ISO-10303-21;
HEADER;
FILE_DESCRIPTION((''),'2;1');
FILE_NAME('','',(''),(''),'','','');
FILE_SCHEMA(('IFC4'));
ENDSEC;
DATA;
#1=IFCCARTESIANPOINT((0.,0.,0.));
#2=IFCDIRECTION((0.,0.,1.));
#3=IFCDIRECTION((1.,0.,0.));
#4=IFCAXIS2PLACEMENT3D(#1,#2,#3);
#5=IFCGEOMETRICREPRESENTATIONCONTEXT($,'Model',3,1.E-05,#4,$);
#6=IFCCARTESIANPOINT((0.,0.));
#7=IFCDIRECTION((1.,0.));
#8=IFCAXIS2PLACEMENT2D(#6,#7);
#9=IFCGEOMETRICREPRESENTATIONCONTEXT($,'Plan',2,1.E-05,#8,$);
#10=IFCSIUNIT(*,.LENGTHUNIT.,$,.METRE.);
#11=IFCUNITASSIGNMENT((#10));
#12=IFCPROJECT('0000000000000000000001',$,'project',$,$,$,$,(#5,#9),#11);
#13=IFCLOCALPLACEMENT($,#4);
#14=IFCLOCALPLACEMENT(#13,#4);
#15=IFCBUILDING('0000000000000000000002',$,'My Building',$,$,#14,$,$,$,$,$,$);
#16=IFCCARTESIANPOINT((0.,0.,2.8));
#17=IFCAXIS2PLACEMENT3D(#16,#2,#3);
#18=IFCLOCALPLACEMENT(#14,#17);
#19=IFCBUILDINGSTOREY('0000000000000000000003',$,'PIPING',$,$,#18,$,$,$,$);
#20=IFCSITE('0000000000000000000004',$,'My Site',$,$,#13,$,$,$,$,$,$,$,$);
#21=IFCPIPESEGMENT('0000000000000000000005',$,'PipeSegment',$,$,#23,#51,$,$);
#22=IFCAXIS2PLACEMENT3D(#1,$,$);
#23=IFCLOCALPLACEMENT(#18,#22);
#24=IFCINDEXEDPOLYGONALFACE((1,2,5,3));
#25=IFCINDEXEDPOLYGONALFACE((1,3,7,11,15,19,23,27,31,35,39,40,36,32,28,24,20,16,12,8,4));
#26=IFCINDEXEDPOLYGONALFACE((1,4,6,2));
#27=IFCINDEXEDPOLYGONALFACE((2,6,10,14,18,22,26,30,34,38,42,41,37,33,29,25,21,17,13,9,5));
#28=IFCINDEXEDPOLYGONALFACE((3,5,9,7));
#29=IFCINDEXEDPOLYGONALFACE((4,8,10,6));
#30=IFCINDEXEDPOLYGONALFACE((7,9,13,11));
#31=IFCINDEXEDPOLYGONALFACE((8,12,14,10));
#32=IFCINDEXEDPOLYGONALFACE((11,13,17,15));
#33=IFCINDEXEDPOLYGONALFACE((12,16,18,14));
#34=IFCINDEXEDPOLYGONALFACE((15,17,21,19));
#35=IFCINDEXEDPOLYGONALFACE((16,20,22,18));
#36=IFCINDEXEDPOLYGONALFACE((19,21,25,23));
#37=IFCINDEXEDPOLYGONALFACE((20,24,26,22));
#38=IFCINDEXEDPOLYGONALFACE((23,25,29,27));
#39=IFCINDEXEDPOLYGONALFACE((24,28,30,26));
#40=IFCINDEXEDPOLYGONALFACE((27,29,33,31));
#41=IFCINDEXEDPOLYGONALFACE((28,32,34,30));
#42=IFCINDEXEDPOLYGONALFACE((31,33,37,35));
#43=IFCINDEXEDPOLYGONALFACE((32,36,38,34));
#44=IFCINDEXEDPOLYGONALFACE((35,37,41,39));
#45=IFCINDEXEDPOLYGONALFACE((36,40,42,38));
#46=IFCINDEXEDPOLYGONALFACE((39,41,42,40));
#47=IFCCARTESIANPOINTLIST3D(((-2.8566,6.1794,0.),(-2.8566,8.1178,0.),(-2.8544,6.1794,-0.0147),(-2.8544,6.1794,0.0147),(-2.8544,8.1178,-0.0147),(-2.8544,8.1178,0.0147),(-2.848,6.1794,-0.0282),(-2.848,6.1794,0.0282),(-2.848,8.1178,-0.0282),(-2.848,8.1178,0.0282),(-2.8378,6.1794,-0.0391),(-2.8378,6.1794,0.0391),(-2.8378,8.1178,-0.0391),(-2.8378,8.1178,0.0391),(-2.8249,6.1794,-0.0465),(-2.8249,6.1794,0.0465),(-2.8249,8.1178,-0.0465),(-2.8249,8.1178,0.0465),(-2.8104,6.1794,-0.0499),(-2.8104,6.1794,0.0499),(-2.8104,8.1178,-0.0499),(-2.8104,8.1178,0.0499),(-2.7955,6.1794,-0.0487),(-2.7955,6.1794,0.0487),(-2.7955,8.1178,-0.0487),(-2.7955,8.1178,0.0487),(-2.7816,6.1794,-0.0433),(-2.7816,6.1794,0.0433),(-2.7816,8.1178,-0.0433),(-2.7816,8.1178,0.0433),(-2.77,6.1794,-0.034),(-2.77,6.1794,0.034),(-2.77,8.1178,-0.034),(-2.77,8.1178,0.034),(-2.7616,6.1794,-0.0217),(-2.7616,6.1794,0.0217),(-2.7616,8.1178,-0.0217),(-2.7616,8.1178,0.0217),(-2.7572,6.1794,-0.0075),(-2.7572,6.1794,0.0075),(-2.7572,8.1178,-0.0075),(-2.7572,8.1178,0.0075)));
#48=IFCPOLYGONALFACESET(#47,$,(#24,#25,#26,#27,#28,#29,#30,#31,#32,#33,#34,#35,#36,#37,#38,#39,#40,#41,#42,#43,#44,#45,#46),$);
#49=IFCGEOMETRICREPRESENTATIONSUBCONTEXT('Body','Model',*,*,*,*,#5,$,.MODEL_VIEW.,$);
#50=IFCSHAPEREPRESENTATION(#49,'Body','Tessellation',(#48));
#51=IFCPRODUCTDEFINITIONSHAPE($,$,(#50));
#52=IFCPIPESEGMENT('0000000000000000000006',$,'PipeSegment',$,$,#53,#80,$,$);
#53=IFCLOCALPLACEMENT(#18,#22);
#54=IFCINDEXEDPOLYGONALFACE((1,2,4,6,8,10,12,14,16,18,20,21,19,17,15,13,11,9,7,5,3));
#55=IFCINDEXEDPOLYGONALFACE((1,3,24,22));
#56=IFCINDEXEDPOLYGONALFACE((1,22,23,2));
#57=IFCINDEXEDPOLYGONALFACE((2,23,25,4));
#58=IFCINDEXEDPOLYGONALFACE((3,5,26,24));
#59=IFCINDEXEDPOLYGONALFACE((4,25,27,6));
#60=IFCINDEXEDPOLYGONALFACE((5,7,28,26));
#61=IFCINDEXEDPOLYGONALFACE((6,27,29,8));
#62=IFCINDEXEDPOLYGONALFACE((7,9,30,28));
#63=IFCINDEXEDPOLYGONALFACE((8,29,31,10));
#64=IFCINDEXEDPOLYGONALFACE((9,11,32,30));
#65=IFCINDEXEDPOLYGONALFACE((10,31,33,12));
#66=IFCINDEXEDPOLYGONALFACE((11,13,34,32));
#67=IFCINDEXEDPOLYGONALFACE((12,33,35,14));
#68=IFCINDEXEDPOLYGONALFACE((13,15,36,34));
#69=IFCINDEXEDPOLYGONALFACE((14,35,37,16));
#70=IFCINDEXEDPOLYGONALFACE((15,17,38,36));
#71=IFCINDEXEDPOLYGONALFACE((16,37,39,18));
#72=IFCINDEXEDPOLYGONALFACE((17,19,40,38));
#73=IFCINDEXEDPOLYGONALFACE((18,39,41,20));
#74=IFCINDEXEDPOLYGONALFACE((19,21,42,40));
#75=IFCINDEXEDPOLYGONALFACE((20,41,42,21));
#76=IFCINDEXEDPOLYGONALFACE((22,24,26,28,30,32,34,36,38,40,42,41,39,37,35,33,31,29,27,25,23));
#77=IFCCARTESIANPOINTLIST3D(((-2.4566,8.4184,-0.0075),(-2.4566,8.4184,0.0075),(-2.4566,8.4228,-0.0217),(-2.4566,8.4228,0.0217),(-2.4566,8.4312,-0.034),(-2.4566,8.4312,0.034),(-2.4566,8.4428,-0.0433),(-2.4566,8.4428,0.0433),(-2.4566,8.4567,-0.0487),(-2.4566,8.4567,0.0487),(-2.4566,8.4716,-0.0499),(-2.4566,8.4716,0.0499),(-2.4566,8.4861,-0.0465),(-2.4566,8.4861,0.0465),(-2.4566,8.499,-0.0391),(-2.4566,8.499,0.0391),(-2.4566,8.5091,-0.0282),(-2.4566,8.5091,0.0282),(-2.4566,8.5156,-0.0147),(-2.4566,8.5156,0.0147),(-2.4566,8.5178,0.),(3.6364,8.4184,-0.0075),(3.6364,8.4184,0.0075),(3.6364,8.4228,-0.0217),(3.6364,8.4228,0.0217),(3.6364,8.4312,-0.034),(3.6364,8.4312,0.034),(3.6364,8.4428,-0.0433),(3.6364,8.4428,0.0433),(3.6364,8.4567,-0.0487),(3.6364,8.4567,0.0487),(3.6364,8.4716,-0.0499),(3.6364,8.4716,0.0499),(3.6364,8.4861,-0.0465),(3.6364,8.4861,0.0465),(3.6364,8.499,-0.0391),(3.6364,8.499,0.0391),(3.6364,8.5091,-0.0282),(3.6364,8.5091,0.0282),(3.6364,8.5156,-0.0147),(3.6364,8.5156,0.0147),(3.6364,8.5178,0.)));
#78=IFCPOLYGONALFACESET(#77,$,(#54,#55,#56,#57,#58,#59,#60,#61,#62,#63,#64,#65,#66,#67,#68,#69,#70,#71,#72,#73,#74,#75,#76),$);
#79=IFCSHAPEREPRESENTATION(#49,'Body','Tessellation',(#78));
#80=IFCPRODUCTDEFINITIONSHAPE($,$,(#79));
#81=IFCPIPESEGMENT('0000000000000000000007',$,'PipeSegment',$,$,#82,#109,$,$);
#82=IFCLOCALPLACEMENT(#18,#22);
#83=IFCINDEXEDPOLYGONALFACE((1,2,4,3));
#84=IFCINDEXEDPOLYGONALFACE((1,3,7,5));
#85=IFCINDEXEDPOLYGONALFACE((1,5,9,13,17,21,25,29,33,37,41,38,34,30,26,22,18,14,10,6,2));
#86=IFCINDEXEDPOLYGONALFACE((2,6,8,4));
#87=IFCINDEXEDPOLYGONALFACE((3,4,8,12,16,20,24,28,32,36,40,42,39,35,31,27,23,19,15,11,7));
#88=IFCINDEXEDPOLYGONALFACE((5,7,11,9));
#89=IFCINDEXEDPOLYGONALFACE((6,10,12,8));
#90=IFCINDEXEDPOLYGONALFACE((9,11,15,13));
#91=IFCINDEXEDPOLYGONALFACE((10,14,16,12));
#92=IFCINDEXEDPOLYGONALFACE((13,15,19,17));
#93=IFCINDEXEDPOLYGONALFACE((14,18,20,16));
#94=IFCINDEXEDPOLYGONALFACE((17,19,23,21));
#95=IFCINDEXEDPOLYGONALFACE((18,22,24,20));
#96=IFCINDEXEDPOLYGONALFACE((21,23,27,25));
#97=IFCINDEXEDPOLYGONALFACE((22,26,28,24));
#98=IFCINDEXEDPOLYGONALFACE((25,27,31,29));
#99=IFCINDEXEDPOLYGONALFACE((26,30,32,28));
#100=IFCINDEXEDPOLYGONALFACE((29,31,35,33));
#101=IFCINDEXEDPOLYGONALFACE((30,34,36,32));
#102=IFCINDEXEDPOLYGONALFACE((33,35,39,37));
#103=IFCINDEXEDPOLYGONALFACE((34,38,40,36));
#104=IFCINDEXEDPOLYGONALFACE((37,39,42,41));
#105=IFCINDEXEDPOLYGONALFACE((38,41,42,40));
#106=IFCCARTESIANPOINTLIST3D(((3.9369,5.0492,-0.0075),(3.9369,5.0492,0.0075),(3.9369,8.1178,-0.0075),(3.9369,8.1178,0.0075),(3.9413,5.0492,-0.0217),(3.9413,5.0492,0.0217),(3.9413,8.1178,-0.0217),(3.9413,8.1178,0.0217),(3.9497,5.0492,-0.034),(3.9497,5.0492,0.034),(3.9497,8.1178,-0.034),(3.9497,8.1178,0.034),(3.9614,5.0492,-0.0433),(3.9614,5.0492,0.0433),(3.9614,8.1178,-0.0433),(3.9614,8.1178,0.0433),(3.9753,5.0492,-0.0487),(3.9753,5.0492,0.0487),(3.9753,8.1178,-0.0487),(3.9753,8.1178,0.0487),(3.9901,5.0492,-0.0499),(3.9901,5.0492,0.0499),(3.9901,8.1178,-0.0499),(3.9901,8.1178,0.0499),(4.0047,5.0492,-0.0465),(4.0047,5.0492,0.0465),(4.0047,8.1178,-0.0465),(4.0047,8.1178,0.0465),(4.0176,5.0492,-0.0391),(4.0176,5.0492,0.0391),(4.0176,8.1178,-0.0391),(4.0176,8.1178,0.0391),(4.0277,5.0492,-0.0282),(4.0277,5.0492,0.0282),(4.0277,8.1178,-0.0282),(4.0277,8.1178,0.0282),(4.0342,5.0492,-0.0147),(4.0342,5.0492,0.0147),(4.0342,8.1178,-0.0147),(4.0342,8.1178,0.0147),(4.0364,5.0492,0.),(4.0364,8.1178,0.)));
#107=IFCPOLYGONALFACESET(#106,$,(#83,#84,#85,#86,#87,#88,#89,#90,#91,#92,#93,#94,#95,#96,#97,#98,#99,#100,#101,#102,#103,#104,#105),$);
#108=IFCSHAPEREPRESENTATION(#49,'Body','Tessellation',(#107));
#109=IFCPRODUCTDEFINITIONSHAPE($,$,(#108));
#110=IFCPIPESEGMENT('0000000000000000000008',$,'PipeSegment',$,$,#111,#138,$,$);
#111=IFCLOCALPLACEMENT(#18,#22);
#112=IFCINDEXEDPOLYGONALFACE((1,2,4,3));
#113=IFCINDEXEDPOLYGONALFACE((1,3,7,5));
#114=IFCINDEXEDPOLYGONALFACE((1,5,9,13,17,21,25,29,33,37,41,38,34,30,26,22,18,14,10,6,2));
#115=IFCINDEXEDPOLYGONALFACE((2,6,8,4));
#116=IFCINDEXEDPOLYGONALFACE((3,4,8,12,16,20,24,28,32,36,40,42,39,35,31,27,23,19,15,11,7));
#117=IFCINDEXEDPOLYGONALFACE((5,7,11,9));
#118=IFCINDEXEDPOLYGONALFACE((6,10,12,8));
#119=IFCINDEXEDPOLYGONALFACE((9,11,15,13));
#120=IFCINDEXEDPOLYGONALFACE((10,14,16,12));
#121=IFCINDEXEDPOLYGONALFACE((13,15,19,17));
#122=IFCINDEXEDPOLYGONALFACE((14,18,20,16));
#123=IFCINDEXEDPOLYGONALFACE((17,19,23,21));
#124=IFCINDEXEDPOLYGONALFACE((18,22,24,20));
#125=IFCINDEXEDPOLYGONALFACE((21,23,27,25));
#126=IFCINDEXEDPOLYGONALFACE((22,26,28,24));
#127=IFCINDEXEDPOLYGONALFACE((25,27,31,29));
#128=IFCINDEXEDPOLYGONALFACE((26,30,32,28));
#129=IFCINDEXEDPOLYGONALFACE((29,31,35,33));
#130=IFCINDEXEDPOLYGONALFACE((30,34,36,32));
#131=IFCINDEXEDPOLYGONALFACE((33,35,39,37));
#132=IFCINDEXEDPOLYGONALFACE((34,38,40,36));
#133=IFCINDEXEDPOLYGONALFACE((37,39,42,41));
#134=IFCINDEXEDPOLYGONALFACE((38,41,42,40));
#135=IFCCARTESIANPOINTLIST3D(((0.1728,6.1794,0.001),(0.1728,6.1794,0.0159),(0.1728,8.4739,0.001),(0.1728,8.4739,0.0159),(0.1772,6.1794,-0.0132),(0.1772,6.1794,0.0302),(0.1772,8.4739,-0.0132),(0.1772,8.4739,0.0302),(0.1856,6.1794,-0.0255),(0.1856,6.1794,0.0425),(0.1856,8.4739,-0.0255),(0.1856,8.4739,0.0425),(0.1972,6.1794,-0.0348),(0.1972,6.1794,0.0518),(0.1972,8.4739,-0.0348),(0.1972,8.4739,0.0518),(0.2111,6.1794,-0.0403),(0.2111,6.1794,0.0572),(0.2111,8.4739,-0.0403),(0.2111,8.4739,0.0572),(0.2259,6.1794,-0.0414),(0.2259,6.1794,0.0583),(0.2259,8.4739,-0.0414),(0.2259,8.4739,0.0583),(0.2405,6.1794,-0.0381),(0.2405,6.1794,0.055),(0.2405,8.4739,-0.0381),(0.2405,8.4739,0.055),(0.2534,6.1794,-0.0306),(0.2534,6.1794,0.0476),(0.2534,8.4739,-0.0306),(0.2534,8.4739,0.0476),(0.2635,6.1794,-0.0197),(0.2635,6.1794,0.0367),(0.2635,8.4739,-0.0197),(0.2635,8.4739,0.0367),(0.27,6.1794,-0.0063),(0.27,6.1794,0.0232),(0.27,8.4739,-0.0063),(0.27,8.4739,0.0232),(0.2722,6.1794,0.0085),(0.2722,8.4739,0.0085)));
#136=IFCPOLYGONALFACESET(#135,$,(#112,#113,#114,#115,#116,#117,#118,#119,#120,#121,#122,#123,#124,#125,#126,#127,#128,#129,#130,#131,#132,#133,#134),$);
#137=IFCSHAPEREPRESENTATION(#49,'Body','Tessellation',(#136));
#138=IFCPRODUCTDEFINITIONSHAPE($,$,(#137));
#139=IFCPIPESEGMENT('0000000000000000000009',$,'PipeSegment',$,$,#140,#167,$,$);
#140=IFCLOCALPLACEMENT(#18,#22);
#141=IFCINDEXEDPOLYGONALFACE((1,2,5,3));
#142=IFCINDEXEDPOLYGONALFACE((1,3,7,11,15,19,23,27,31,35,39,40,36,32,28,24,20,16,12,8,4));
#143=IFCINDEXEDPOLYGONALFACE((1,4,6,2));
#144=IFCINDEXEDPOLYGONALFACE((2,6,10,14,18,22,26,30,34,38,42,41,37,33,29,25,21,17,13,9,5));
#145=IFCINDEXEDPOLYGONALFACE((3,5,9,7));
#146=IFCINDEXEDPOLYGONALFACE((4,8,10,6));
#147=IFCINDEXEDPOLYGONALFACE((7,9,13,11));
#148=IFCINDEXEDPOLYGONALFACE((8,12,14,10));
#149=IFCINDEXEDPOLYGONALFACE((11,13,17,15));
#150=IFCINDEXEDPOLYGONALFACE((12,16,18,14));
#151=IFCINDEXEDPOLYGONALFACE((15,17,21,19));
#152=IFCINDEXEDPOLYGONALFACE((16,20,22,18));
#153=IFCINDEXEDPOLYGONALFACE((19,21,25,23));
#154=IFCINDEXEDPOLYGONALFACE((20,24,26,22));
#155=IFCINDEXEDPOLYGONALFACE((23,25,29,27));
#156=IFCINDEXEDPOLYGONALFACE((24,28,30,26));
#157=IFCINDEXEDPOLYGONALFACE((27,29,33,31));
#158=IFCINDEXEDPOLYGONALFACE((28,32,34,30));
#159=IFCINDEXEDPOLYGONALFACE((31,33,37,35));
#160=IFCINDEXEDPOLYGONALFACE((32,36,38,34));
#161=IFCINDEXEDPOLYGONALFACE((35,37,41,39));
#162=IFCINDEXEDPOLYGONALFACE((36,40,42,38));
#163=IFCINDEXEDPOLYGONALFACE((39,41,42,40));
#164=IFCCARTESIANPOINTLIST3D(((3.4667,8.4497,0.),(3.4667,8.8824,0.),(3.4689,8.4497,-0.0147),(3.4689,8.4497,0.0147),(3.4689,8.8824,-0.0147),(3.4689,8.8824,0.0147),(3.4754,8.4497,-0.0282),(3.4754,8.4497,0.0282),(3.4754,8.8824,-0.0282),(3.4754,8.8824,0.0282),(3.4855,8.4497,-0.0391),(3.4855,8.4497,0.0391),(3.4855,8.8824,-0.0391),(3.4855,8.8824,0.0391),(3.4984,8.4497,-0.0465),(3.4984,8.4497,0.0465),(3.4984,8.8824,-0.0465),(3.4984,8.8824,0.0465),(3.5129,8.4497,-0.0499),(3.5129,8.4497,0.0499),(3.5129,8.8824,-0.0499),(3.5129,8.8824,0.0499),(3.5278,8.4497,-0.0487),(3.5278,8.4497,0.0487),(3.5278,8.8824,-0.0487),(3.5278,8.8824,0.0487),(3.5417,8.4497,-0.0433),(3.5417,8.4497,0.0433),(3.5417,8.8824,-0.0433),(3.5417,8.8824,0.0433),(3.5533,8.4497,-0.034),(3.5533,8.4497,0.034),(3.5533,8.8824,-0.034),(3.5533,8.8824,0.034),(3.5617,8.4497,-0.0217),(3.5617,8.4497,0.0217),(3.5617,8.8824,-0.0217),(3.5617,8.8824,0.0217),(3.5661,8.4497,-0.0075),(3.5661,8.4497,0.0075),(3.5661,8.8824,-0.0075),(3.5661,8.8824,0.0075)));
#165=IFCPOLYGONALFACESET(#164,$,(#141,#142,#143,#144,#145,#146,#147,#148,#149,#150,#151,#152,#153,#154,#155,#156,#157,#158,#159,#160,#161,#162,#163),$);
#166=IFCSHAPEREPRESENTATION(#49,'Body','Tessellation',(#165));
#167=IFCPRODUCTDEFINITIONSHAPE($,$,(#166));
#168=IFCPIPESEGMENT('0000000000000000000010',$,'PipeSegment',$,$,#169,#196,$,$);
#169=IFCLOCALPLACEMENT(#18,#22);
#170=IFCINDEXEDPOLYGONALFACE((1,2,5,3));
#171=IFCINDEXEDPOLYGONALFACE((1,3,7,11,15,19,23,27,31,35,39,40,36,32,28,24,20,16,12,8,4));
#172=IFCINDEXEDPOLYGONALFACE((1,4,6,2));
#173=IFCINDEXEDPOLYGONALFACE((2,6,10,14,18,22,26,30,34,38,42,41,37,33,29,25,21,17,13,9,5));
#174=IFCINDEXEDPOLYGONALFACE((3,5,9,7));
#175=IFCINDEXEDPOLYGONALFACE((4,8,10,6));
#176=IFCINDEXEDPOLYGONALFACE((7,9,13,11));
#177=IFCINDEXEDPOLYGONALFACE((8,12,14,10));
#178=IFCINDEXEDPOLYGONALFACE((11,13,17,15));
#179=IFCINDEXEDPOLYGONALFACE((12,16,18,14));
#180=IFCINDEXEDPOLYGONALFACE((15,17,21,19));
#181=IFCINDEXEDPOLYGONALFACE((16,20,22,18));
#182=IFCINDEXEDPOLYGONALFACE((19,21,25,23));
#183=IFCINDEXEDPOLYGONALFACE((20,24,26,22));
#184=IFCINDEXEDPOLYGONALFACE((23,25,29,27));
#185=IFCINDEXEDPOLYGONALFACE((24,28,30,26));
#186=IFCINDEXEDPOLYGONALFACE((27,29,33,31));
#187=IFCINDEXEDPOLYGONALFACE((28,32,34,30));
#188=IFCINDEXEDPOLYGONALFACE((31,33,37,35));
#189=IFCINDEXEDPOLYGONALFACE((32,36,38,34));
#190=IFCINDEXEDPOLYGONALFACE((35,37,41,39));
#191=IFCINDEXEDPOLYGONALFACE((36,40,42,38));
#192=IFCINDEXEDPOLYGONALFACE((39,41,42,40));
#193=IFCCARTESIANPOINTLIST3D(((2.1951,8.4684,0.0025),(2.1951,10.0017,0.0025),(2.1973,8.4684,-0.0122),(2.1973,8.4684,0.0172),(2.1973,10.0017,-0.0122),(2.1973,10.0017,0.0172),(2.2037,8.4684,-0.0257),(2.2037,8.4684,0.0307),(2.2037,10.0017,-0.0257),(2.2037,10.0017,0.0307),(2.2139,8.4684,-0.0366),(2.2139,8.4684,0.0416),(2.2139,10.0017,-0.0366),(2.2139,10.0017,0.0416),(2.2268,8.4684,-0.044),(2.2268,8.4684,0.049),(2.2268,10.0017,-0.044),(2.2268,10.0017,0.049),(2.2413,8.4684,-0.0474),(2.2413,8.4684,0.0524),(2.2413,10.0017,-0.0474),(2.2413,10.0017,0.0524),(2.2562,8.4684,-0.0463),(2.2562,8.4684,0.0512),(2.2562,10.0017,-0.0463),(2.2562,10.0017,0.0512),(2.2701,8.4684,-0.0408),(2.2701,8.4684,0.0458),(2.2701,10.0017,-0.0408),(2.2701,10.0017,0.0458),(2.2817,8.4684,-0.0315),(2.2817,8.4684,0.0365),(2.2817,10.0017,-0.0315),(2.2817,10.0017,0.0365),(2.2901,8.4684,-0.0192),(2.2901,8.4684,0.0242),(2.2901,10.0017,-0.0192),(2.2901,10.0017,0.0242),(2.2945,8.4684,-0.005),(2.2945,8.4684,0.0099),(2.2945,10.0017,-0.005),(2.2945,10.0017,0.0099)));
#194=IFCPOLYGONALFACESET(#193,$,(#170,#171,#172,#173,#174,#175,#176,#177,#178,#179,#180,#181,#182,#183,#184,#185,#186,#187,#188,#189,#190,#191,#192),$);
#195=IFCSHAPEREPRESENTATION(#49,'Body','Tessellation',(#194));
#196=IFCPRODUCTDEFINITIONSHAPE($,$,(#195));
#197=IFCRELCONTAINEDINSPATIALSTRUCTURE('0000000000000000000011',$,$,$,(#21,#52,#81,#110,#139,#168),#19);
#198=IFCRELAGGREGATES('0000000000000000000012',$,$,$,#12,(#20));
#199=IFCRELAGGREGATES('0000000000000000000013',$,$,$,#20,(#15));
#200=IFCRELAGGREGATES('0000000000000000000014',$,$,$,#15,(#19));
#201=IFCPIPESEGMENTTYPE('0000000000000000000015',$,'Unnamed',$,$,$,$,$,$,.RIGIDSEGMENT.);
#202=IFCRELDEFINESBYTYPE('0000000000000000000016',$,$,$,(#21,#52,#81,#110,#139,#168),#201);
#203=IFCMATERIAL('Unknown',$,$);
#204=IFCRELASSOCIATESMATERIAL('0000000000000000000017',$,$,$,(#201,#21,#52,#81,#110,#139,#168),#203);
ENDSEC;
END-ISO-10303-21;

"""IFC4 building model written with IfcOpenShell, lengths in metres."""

from ifc_helpers import new_model, si_unit, frame, origin_with_axes, origin_2d_with_axis, place, context, subcontext, project, spatial, circle, extrude, material, material_profile, profile_set, profile_usage, type_object, element, save


model = new_model("IFC4")

# Units and contexts
model_context = context("Model", 3, precision=1e-05, world=origin_with_axes())
plan_context = context("Plan", 2, precision=1e-05, world=origin_2d_with_axis())
body_context = subcontext(model_context, "Body", "Model", "MODEL_VIEW")
ifc_project = project(units=[si_unit("LENGTHUNIT", "METRE")], contexts=[model_context, plan_context])

# Site, building, storey
site_placement = place(None, origin_with_axes())
site = spatial("IfcSite", under=ifc_project, at=site_placement, Name="My Site")
building_placement = place(site_placement, origin_with_axes())
building = spatial("IfcBuilding", under=site, at=building_placement, Name="My Building")
storey_placement = place(building_placement, frame((0.0, 0.0, 2.8), z_axis=(0.0, 0.0, 1.0), x_axis=(1.0, 0.0, 0.0)))
storey = spatial("IfcBuildingStorey", under=building, at=storey_placement, Name="PIPING")

# Pipe segments
ifc_material = material(Name="Unknown")
ifc_material_profile = material_profile(ifc_material, circle(Radius=0.05))
ifc_profile_set = profile_set([ifc_material_profile])
ifc_profile_usage_1 = profile_usage(ifc_profile_set, cardinal=5)
pipe_segment_type = type_object("IfcPipeSegmentType", Name="Unnamed", PredefinedType="RIGIDSEGMENT", material=ifc_profile_set)
pipe_segment_1_placement = place(storey_placement, frame((-2.8066, 6.1794, 0.0), z_axis=(0.0, 1.0, 0.0), x_axis=(-1.0, 0.0, 0.0)))
element("IfcPipeSegment", 1, at=pipe_segment_1_placement, inside=storey, type_object=pipe_segment_type, material=ifc_profile_usage_1, Name="PipeSegment", context=body_context, shape_type="SweptSolid", body=[
    extrude(circle(Radius=0.05), origin_with_axes(), (0.0, 0.0, 1.0), 1.9384),
])
ifc_profile_usage_2 = profile_usage(ifc_profile_set, cardinal=5)
pipe_segment_2_placement = place(storey_placement, frame((-2.4566, 8.4678, 0.0), z_axis=(1.0, 0.0, 0.0), x_axis=(0.0, 1.0, 0.0)))
element("IfcPipeSegment", 2, at=pipe_segment_2_placement, inside=storey, type_object=pipe_segment_type, material=ifc_profile_usage_2, Name="PipeSegment", context=body_context, shape_type="SweptSolid", body=[
    extrude(circle(Radius=0.05), origin_with_axes(), (0.0, 0.0, 1.0), 6.093),
])
ifc_profile_usage_3 = profile_usage(ifc_profile_set, cardinal=5)
pipe_segment_3_placement = place(storey_placement, frame((3.9864, 8.1178, 0.0), z_axis=(0.0, -1.0, 0.0), x_axis=(1.0, 0.0, 0.0)))
element("IfcPipeSegment", 3, at=pipe_segment_3_placement, inside=storey, type_object=pipe_segment_type, material=ifc_profile_usage_3, Name="PipeSegment", context=body_context, shape_type="SweptSolid", body=[
    extrude(circle(Radius=0.05), origin_with_axes(), (0.0, 0.0, 1.0), 3.0686),
])
ifc_profile_usage_4 = profile_usage(ifc_profile_set, cardinal=5)
pipe_segment_4_placement = place(storey_placement, frame((0.2222, 8.4739, 0.0085), z_axis=(0.0, -1.0, 0.0), x_axis=(1.0, 0.0, 0.0)))
element("IfcPipeSegment", 4, at=pipe_segment_4_placement, inside=storey, type_object=pipe_segment_type, material=ifc_profile_usage_4, Name="PipeSegment", context=body_context, shape_type="SweptSolid", body=[
    extrude(circle(Radius=0.05), origin_with_axes(), (0.0, 0.0, 1.0), 2.2944),
])
ifc_profile_usage_5 = profile_usage(ifc_profile_set, cardinal=5)
pipe_segment_5_placement = place(storey_placement, frame((3.5167, 8.4497, 0.0), z_axis=(0.0, 1.0, 0.0), x_axis=(-1.0, 0.0, 0.0)))
element("IfcPipeSegment", 5, at=pipe_segment_5_placement, inside=storey, type_object=pipe_segment_type, material=ifc_profile_usage_5, Name="PipeSegment", context=body_context, shape_type="SweptSolid", body=[
    extrude(circle(Radius=0.05), origin_with_axes(), (0.0, 0.0, 1.0), 0.4326),
])
ifc_profile_usage_6 = profile_usage(ifc_profile_set, cardinal=5)
pipe_segment_6_placement = place(storey_placement, frame((2.2451, 8.4684, 0.0025), z_axis=(0.0, 1.0, 0.0), x_axis=(-1.0, 0.0, 0.0)))
element("IfcPipeSegment", 6, at=pipe_segment_6_placement, inside=storey, type_object=pipe_segment_type, material=ifc_profile_usage_6, Name="PipeSegment", context=body_context, shape_type="SweptSolid", body=[
    extrude(circle(Radius=0.05), origin_with_axes(), (0.0, 0.0, 1.0), 1.5333),
])

save(model, "model.ifc")
